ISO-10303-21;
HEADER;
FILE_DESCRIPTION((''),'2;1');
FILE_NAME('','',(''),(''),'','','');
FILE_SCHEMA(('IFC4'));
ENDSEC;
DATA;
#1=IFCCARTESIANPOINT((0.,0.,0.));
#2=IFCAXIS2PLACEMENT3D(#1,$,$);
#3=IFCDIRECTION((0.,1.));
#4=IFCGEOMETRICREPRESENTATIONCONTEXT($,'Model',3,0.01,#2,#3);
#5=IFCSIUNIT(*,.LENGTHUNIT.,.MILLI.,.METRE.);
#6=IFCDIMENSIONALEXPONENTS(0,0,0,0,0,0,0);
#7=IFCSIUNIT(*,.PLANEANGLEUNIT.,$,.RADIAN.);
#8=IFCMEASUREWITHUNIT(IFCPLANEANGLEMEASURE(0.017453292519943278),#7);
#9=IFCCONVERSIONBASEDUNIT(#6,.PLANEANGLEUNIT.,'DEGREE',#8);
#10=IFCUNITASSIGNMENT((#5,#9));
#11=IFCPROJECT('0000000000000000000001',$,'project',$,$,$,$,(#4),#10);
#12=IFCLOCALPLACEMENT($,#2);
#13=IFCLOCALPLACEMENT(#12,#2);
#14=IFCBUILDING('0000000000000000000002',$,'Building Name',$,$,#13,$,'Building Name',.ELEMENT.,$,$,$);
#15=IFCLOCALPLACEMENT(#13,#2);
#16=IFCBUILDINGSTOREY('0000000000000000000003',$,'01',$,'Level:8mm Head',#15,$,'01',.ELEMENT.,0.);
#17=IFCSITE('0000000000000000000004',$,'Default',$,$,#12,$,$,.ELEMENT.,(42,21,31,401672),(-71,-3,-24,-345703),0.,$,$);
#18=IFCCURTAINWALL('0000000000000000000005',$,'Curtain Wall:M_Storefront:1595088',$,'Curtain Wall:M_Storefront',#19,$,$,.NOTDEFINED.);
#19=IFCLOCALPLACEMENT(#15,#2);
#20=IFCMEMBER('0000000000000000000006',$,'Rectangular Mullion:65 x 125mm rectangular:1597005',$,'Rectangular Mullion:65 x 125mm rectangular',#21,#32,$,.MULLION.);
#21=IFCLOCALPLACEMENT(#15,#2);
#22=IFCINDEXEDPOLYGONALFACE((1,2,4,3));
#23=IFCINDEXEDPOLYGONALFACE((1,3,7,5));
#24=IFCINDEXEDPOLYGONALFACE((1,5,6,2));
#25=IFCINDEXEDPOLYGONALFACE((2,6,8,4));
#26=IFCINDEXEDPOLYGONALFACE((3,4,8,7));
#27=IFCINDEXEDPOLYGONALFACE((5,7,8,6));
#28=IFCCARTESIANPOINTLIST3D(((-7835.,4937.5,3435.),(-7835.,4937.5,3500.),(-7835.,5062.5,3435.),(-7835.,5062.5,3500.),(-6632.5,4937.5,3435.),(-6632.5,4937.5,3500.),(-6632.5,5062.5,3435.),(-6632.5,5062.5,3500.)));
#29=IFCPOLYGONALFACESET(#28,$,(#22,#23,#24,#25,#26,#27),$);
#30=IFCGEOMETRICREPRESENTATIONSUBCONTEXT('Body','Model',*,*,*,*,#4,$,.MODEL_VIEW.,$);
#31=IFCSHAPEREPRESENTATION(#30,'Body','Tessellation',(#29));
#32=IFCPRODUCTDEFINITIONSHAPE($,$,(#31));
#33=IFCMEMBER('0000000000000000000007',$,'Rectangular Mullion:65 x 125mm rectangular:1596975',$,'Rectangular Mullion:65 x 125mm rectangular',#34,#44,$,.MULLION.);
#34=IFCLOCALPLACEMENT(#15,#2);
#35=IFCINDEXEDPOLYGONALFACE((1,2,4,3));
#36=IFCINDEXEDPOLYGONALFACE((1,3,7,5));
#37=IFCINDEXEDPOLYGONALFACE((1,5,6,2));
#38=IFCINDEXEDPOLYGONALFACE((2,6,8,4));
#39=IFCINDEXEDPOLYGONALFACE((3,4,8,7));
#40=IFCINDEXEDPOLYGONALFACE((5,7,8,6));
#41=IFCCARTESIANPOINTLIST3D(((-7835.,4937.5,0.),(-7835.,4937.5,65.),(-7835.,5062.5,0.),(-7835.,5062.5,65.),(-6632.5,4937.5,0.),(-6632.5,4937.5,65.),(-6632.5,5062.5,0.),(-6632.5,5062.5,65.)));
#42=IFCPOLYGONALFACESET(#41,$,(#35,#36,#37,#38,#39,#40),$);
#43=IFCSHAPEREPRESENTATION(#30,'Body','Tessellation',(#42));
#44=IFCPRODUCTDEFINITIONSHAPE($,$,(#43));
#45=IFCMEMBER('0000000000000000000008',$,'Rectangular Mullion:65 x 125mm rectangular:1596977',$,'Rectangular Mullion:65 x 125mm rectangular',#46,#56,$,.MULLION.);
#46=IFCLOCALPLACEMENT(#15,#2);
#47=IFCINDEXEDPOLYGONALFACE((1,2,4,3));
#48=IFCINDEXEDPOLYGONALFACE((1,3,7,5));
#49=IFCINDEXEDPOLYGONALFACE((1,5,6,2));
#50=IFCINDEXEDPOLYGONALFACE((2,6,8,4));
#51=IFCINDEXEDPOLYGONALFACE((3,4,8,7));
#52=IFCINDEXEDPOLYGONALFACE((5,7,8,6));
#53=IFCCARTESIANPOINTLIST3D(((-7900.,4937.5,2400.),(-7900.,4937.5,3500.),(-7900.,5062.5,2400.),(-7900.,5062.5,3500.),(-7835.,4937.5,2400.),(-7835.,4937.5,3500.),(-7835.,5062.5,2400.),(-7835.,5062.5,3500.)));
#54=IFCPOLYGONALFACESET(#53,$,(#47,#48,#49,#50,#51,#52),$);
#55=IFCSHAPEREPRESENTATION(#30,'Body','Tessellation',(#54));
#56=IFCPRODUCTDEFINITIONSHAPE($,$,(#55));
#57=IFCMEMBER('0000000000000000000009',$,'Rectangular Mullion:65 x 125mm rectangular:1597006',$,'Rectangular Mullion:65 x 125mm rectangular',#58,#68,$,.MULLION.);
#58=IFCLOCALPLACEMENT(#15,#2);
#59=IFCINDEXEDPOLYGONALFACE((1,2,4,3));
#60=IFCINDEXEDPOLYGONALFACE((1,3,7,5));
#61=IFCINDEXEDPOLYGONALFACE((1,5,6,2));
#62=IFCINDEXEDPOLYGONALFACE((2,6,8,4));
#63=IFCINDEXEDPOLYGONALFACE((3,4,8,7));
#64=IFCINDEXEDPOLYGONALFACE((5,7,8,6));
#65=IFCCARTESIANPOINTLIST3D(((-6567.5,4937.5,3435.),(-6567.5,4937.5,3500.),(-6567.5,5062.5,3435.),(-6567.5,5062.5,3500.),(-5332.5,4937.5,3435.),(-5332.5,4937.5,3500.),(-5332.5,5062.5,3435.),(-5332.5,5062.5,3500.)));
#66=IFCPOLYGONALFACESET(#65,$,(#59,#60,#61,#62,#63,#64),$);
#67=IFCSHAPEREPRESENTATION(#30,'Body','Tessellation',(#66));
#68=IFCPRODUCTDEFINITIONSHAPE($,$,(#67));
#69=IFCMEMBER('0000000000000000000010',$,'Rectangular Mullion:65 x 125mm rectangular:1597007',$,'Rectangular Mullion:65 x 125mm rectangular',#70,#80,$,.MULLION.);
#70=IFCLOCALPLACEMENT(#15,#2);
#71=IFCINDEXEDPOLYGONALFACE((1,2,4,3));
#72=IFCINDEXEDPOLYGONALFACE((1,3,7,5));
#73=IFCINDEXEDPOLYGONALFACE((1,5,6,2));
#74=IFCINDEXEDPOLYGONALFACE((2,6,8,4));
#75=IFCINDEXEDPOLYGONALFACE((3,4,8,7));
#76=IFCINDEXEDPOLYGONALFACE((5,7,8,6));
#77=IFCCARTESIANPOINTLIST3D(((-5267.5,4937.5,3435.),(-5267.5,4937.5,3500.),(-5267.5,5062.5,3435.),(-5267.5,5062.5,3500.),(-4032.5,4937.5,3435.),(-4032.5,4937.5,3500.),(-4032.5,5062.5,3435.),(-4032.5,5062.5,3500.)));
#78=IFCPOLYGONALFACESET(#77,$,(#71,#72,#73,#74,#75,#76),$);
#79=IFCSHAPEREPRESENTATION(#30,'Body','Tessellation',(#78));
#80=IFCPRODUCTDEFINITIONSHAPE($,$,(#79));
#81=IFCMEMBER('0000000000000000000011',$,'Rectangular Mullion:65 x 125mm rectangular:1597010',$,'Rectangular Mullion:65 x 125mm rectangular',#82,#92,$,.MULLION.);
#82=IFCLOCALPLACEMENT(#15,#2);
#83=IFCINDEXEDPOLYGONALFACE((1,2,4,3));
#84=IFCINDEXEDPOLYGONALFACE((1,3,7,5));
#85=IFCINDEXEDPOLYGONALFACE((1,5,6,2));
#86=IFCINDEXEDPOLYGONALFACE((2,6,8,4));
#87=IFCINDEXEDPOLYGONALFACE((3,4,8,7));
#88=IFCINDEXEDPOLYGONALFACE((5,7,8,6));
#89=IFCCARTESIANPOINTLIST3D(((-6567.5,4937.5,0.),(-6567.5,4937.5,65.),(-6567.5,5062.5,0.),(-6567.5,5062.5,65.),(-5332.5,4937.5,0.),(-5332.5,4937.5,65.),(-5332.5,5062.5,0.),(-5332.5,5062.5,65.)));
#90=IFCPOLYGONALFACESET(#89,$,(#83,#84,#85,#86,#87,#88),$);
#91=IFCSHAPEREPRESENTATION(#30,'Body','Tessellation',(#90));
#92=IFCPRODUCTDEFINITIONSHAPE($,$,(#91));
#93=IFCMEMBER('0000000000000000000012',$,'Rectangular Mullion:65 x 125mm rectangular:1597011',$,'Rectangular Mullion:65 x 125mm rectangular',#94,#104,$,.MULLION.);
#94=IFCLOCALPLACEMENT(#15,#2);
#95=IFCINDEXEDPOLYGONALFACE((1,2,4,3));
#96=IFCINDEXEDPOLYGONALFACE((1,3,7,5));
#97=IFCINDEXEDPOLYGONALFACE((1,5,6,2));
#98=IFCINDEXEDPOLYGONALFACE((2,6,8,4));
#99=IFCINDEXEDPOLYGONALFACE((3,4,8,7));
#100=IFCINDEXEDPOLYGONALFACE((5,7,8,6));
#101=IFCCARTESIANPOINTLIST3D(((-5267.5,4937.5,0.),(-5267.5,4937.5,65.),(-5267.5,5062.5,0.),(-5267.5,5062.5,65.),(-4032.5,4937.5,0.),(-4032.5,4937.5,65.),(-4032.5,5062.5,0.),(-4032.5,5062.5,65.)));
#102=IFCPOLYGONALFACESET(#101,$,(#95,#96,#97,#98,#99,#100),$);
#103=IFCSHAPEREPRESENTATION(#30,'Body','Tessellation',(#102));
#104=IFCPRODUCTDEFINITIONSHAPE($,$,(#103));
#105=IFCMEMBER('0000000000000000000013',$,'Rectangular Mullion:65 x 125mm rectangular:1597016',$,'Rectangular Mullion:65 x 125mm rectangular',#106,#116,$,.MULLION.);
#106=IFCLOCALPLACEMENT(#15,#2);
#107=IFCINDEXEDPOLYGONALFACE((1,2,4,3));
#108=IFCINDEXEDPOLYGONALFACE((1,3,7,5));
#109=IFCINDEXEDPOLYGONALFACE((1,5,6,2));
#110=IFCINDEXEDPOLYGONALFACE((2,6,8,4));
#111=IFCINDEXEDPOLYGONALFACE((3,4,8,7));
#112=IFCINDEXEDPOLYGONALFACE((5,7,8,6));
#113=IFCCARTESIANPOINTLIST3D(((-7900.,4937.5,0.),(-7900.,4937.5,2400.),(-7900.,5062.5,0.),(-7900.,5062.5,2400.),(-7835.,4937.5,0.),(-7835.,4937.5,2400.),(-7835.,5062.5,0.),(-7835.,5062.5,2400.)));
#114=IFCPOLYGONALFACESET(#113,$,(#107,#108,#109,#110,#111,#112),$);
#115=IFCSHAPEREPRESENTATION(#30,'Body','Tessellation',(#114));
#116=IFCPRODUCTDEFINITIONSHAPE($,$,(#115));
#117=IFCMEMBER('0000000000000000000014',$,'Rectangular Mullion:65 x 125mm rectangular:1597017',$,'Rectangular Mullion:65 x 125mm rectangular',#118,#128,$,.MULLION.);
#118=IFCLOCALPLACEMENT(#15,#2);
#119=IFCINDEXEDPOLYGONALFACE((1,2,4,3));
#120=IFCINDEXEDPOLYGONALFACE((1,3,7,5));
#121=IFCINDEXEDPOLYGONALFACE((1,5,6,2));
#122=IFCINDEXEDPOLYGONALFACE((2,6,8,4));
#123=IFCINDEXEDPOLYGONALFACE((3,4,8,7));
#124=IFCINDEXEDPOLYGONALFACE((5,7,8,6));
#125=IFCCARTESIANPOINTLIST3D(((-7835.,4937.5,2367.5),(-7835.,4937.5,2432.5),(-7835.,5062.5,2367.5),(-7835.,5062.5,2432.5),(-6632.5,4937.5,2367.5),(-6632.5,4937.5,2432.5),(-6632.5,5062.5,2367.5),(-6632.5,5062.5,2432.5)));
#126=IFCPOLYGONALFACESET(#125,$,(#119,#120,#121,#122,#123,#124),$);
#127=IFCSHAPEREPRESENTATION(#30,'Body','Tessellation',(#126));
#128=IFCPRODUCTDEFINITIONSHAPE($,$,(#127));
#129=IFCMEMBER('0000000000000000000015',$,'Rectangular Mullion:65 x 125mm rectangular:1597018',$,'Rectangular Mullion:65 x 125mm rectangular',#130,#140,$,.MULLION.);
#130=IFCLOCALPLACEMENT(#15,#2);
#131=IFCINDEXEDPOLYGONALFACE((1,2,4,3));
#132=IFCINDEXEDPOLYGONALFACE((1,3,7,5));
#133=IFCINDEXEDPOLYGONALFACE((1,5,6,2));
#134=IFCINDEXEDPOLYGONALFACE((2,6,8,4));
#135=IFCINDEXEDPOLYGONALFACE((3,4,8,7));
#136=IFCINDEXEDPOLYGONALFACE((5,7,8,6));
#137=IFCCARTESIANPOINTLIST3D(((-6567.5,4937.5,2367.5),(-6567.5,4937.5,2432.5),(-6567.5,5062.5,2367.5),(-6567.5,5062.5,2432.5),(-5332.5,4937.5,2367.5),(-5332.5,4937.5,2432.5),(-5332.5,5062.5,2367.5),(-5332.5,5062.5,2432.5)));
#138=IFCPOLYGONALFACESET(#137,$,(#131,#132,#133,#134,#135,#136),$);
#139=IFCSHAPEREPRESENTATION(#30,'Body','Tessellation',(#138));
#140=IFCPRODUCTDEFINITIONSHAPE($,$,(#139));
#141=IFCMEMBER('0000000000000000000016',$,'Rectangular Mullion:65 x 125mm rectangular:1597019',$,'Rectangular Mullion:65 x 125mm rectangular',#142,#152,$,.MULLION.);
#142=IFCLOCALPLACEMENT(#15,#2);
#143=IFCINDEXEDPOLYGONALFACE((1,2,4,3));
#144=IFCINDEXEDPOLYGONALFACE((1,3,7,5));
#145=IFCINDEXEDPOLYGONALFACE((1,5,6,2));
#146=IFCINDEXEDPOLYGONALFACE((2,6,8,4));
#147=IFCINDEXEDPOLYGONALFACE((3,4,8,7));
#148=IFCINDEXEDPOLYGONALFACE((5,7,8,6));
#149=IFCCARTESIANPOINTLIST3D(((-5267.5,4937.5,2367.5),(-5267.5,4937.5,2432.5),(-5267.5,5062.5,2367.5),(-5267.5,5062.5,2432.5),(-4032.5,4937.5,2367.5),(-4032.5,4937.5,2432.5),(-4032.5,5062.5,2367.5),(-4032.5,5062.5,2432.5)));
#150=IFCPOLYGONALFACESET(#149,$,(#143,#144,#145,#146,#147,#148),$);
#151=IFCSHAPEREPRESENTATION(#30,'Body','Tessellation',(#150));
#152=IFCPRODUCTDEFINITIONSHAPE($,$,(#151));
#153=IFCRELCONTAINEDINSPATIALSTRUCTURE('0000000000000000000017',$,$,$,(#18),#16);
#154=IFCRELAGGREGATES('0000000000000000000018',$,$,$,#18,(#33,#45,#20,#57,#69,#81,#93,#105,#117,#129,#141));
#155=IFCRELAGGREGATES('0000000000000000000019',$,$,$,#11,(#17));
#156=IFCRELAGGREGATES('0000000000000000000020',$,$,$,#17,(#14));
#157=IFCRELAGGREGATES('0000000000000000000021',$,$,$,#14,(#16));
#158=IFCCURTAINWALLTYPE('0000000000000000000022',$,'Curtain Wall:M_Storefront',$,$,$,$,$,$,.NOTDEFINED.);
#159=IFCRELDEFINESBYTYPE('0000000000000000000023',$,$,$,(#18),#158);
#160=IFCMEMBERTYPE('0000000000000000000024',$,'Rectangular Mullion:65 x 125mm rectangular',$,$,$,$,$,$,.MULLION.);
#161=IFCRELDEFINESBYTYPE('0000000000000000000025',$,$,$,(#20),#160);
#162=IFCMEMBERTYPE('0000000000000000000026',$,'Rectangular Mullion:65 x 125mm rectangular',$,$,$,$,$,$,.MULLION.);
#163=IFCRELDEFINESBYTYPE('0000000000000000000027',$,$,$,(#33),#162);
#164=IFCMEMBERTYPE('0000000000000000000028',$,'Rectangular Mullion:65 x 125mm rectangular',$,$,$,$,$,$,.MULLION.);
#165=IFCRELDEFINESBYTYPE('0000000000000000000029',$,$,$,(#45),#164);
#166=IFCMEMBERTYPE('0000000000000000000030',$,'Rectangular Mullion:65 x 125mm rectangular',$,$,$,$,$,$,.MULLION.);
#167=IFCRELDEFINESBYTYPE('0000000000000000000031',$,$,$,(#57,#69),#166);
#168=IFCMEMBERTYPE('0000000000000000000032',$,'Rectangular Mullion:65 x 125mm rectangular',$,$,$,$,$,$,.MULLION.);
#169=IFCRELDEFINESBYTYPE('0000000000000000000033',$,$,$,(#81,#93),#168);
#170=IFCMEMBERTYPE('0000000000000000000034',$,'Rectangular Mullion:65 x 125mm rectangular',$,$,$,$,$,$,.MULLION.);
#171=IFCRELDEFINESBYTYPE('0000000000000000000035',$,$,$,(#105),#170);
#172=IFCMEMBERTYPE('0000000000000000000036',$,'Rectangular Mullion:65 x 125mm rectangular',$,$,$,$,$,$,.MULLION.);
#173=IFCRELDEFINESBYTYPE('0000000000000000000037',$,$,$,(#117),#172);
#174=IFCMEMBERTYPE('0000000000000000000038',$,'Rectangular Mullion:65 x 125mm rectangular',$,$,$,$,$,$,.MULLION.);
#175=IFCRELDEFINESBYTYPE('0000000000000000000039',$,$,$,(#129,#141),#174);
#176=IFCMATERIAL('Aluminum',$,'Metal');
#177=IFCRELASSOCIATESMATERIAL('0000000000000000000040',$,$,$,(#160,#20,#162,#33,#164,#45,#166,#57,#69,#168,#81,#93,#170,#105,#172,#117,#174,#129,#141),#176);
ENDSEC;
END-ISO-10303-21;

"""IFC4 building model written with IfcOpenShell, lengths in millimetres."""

from ifc_helpers import new_model, entity, si_unit, converted_unit, direction, frame, origin, place, context, subcontext, project, spatial, indexed_curve, outline, extrude, source, transform, mapped, material, type_object, type_shapes, element, aggregate, save


model = new_model("IFC4")

# Units and contexts
model_context = context("Model", 3, precision=0.01, world=origin(), true_north=direction((0.0, 1.0)))
body_context = subcontext(model_context, "Body", "Model", "MODEL_VIEW")
ifc_project = project(units=[si_unit("LENGTHUNIT", "METRE", prefix="MILLI"), converted_unit("PLANEANGLEUNIT", "DEGREE", entity("IfcPlaneAngleMeasure", 0.017453292519943278), si_unit("PLANEANGLEUNIT", "RADIAN"), dimensions=[0, 0, 0, 0, 0, 0, 0])], contexts=[model_context])

# Site, building, storey
site_placement = place(None, origin())
site = spatial("IfcSite", under=ifc_project, at=site_placement, Name="Default", CompositionType="ELEMENT", RefLatitude=(42, 21, 31, 401672), RefLongitude=(-71, -3, -24, -345703), RefElevation=0.0)
building_placement = place(site_placement, origin())
building = spatial("IfcBuilding", under=site, at=building_placement, Name="Building Name", LongName="Building Name", CompositionType="ELEMENT")
storey_placement = place(building_placement, origin())
storey = spatial("IfcBuildingStorey", under=building, at=storey_placement, Name="01", ObjectType="Level:8mm Head", LongName="01", CompositionType="ELEMENT", Elevation=0.0)

# Curtain wall, members
curtain_wall_type = type_object("IfcCurtainWallType", Name="Curtain Wall:M_Storefront", PredefinedType="NOTDEFINED")
curtain_wall_placement = place(storey_placement, origin())
curtain_wall = element("IfcCurtainWall", 1, at=curtain_wall_placement, inside=storey, type_object=curtain_wall_type, Name="Curtain Wall:M_Storefront:1595088", ObjectType="Curtain Wall:M_Storefront", PredefinedType="NOTDEFINED")
ifc_material_1 = material(Name="Aluminum", Category="Metal")
member_type_1 = type_object("IfcMemberType", Name="Rectangular Mullion:65 x 125mm rectangular", PredefinedType="MULLION", material=ifc_material_1)
shared_shape_1 = source(origin(), body_context, "Body", "SweptSolid", [
    extrude(outline(indexed_curve([(-32.5, -62.5), (32.5, -62.5), (32.5, 62.5), (-32.5, 62.5), (-32.5, -62.5)], self_intersect=False)), frame((-32.5, 0.0, -1202.5), z_axis=(0.0, 0.0, 1.0), x_axis=(-1.0, 0.0, 0.0)), (0.0, 0.0, 1.0), 1202.5),
])
type_shapes(member_type_1, [shared_shape_1])
member_1_placement = place(curtain_wall_placement, frame((-6632.5, 5000.0, 3500.0), z_axis=(1.0, 0.0, 0.0), x_axis=(0.0, 0.0, 1.0)))
member_1 = element("IfcMember", 2, at=member_1_placement, type_object=member_type_1, material=ifc_material_1, Name="Rectangular Mullion:65 x 125mm rectangular:1597005", ObjectType="Rectangular Mullion:65 x 125mm rectangular", PredefinedType="MULLION", context=body_context, shape_type="MappedRepresentation", body=[
    mapped(shared_shape_1, transform((0.0, 0.0, 0.0), scale=1.0)),
])
member_type_2 = type_object("IfcMemberType", Name="Rectangular Mullion:65 x 125mm rectangular", PredefinedType="MULLION", material=ifc_material_1)
shared_shape_2 = source(origin(), body_context, "Body", "SweptSolid", [
    extrude(outline(indexed_curve([(-32.5, -62.5), (32.5, -62.5), (32.5, 62.5), (-32.5, 62.5), (-32.5, -62.5)], self_intersect=False)), frame((-32.5, 0.0, -1202.5), z_axis=(0.0, 0.0, 1.0), x_axis=(-1.0, 0.0, 0.0)), (0.0, 0.0, 1.0), 1202.5),
])
type_shapes(member_type_2, [shared_shape_2])
member_2_placement = place(curtain_wall_placement, frame((-7835.0, 5000.0, 0.0), z_axis=(-1.0, 0.0, 0.0), x_axis=(0.0, 0.0, -1.0)))
member_2 = element("IfcMember", 3, at=member_2_placement, type_object=member_type_2, material=ifc_material_1, Name="Rectangular Mullion:65 x 125mm rectangular:1596975", ObjectType="Rectangular Mullion:65 x 125mm rectangular", PredefinedType="MULLION", context=body_context, shape_type="MappedRepresentation", body=[
    mapped(shared_shape_2, transform((0.0, 0.0, 0.0), scale=1.0)),
])
member_type_3 = type_object("IfcMemberType", Name="Rectangular Mullion:65 x 125mm rectangular", PredefinedType="MULLION", material=ifc_material_1)
shared_shape_3 = source(origin(), body_context, "Body", "SweptSolid", [
    extrude(outline(indexed_curve([(-32.5, -62.5), (32.5, -62.5), (32.5, 62.5), (-32.5, 62.5), (-32.5, -62.5)], self_intersect=False)), frame((-32.5, 0.0, -1100.0), z_axis=(0.0, 0.0, 1.0), x_axis=(-1.0, 0.0, 0.0)), (0.0, 0.0, 1.0), 1100.0),
])
type_shapes(member_type_3, [shared_shape_3])
member_3_placement = place(curtain_wall_placement, frame((-7900.0, 5000.0, 3500.0), z_axis=(0.0, 0.0, 1.0), x_axis=(-1.0, 0.0, 0.0)))
member_3 = element("IfcMember", 4, at=member_3_placement, type_object=member_type_3, material=ifc_material_1, Name="Rectangular Mullion:65 x 125mm rectangular:1596977", ObjectType="Rectangular Mullion:65 x 125mm rectangular", PredefinedType="MULLION", context=body_context, shape_type="MappedRepresentation", body=[
    mapped(shared_shape_3, transform((0.0, 0.0, 0.0), scale=1.0)),
])
member_type_4 = type_object("IfcMemberType", Name="Rectangular Mullion:65 x 125mm rectangular", PredefinedType="MULLION", material=ifc_material_1)
shared_shape_4 = source(origin(), body_context, "Body", "SweptSolid", [
    extrude(outline(indexed_curve([(-32.5, -62.5), (32.5, -62.5), (32.5, 62.5), (-32.5, 62.5), (-32.5, -62.5)], self_intersect=False)), frame((-32.5, 0.0, -1235.0), z_axis=(0.0, 0.0, 1.0), x_axis=(-1.0, 0.0, 0.0)), (0.0, 0.0, 1.0), 1235.0),
])
type_shapes(member_type_4, [shared_shape_4])
member_4_placement = place(curtain_wall_placement, frame((-5332.5, 5000.0, 3500.0), z_axis=(1.0, 0.0, 0.0), x_axis=(0.0, 0.0, 1.0)))
member_4 = element("IfcMember", 5, at=member_4_placement, type_object=member_type_4, material=ifc_material_1, Name="Rectangular Mullion:65 x 125mm rectangular:1597006", ObjectType="Rectangular Mullion:65 x 125mm rectangular", PredefinedType="MULLION", context=body_context, shape_type="MappedRepresentation", body=[
    mapped(shared_shape_4, transform((0.0, 0.0, 0.0), scale=1.0)),
])
member_5_placement = place(curtain_wall_placement, frame((-4032.5, 5000.0, 3500.0), z_axis=(1.0, 0.0, 0.0), x_axis=(0.0, 0.0, 1.0)))
member_5 = element("IfcMember", 6, at=member_5_placement, type_object=member_type_4, material=ifc_material_1, Name="Rectangular Mullion:65 x 125mm rectangular:1597007", ObjectType="Rectangular Mullion:65 x 125mm rectangular", PredefinedType="MULLION", context=body_context, shape_type="MappedRepresentation", body=[
    mapped(shared_shape_4, transform((0.0, 0.0, 0.0), scale=1.0)),
])
member_type_5 = type_object("IfcMemberType", Name="Rectangular Mullion:65 x 125mm rectangular", PredefinedType="MULLION", material=ifc_material_1)
shared_shape_5 = source(origin(), body_context, "Body", "SweptSolid", [
    extrude(outline(indexed_curve([(-32.5, -62.5), (32.5, -62.5), (32.5, 62.5), (-32.5, 62.5), (-32.5, -62.5)], self_intersect=False)), frame((-32.5, 0.0, -1235.0), z_axis=(0.0, 0.0, 1.0), x_axis=(-1.0, 0.0, 0.0)), (0.0, 0.0, 1.0), 1235.0),
])
type_shapes(member_type_5, [shared_shape_5])
member_6_placement = place(curtain_wall_placement, frame((-6567.5, 5000.0, 0.0), z_axis=(-1.0, 0.0, 0.0), x_axis=(0.0, 0.0, -1.0)))
member_6 = element("IfcMember", 7, at=member_6_placement, type_object=member_type_5, material=ifc_material_1, Name="Rectangular Mullion:65 x 125mm rectangular:1597010", ObjectType="Rectangular Mullion:65 x 125mm rectangular", PredefinedType="MULLION", context=body_context, shape_type="MappedRepresentation", body=[
    mapped(shared_shape_5, transform((0.0, 0.0, 0.0), scale=1.0)),
])
member_7_placement = place(curtain_wall_placement, frame((-5267.5, 5000.0, 0.0), z_axis=(-1.0, 0.0, 0.0), x_axis=(0.0, 0.0, -1.0)))
member_7 = element("IfcMember", 8, at=member_7_placement, type_object=member_type_5, material=ifc_material_1, Name="Rectangular Mullion:65 x 125mm rectangular:1597011", ObjectType="Rectangular Mullion:65 x 125mm rectangular", PredefinedType="MULLION", context=body_context, shape_type="MappedRepresentation", body=[
    mapped(shared_shape_5, transform((0.0, 0.0, 0.0), scale=1.0)),
])
member_type_6 = type_object("IfcMemberType", Name="Rectangular Mullion:65 x 125mm rectangular", PredefinedType="MULLION", material=ifc_material_1)
shared_shape_6 = source(origin(), body_context, "Body", "SweptSolid", [
    extrude(outline(indexed_curve([(-32.5, -62.5), (32.5, -62.5), (32.5, 62.5), (-32.5, 62.5), (-32.5, -62.5)], self_intersect=False)), frame((-32.5, 0.0, -2400.0), z_axis=(0.0, 0.0, 1.0), x_axis=(-1.0, 0.0, 0.0)), (0.0, 0.0, 1.0), 2400.0),
])
type_shapes(member_type_6, [shared_shape_6])
member_8_placement = place(curtain_wall_placement, frame((-7900.0, 5000.0, 2400.0), z_axis=(0.0, 0.0, 1.0), x_axis=(-1.0, 0.0, 0.0)))
member_8 = element("IfcMember", 9, at=member_8_placement, type_object=member_type_6, material=ifc_material_1, Name="Rectangular Mullion:65 x 125mm rectangular:1597016", ObjectType="Rectangular Mullion:65 x 125mm rectangular", PredefinedType="MULLION", context=body_context, shape_type="MappedRepresentation", body=[
    mapped(shared_shape_6, transform((0.0, 0.0, 0.0), scale=1.0)),
])
member_type_7 = type_object("IfcMemberType", Name="Rectangular Mullion:65 x 125mm rectangular", PredefinedType="MULLION", material=ifc_material_1)
shared_shape_7 = source(origin(), body_context, "Body", "SweptSolid", [
    extrude(outline(indexed_curve([(-32.5, -62.5), (32.5, -62.5), (32.5, 62.5), (-32.5, 62.5), (-32.5, -62.5)], self_intersect=False)), frame((0.0, 0.0, -1202.5), z_axis=(0.0, 0.0, 1.0), x_axis=(-1.0, 0.0, 0.0)), (0.0, 0.0, 1.0), 1202.5),
])
type_shapes(member_type_7, [shared_shape_7])
member_9_placement = place(curtain_wall_placement, frame((-6632.5, 5000.0, 2400.0), z_axis=(1.0, 0.0, 0.0), x_axis=(0.0, 0.0, 1.0)))
member_9 = element("IfcMember", 10, at=member_9_placement, type_object=member_type_7, material=ifc_material_1, Name="Rectangular Mullion:65 x 125mm rectangular:1597017", ObjectType="Rectangular Mullion:65 x 125mm rectangular", PredefinedType="MULLION", context=body_context, shape_type="MappedRepresentation", body=[
    mapped(shared_shape_7, transform((0.0, 0.0, 0.0), scale=1.0)),
])
member_type_8 = type_object("IfcMemberType", Name="Rectangular Mullion:65 x 125mm rectangular", PredefinedType="MULLION", material=ifc_material_1)
shared_shape_8 = source(origin(), body_context, "Body", "SweptSolid", [
    extrude(outline(indexed_curve([(-32.5, -62.5), (32.5, -62.5), (32.5, 62.5), (-32.5, 62.5), (-32.5, -62.5)], self_intersect=False)), frame((0.0, 0.0, -1235.0), z_axis=(0.0, 0.0, 1.0), x_axis=(-1.0, 0.0, 0.0)), (0.0, 0.0, 1.0), 1235.0),
])
type_shapes(member_type_8, [shared_shape_8])
member_10_placement = place(curtain_wall_placement, frame((-5332.5, 5000.0, 2400.0), z_axis=(1.0, 0.0, 0.0), x_axis=(0.0, 0.0, 1.0)))
member_10 = element("IfcMember", 11, at=member_10_placement, type_object=member_type_8, material=ifc_material_1, Name="Rectangular Mullion:65 x 125mm rectangular:1597018", ObjectType="Rectangular Mullion:65 x 125mm rectangular", PredefinedType="MULLION", context=body_context, shape_type="MappedRepresentation", body=[
    mapped(shared_shape_8, transform((0.0, 0.0, 0.0), scale=1.0)),
])
member_11_placement = place(curtain_wall_placement, frame((-4032.5, 5000.0, 2400.0), z_axis=(1.0, 0.0, 0.0), x_axis=(0.0, 0.0, 1.0)))
member_11 = element("IfcMember", 12, at=member_11_placement, type_object=member_type_8, material=ifc_material_1, Name="Rectangular Mullion:65 x 125mm rectangular:1597019", ObjectType="Rectangular Mullion:65 x 125mm rectangular", PredefinedType="MULLION", context=body_context, shape_type="MappedRepresentation", body=[
    mapped(shared_shape_8, transform((0.0, 0.0, 0.0), scale=1.0)),
])
aggregate(curtain_wall, [member_2, member_3, member_1, member_4, member_5, member_6, member_7, member_8, member_9, member_10, member_11])

save(model, "model.ifc")
